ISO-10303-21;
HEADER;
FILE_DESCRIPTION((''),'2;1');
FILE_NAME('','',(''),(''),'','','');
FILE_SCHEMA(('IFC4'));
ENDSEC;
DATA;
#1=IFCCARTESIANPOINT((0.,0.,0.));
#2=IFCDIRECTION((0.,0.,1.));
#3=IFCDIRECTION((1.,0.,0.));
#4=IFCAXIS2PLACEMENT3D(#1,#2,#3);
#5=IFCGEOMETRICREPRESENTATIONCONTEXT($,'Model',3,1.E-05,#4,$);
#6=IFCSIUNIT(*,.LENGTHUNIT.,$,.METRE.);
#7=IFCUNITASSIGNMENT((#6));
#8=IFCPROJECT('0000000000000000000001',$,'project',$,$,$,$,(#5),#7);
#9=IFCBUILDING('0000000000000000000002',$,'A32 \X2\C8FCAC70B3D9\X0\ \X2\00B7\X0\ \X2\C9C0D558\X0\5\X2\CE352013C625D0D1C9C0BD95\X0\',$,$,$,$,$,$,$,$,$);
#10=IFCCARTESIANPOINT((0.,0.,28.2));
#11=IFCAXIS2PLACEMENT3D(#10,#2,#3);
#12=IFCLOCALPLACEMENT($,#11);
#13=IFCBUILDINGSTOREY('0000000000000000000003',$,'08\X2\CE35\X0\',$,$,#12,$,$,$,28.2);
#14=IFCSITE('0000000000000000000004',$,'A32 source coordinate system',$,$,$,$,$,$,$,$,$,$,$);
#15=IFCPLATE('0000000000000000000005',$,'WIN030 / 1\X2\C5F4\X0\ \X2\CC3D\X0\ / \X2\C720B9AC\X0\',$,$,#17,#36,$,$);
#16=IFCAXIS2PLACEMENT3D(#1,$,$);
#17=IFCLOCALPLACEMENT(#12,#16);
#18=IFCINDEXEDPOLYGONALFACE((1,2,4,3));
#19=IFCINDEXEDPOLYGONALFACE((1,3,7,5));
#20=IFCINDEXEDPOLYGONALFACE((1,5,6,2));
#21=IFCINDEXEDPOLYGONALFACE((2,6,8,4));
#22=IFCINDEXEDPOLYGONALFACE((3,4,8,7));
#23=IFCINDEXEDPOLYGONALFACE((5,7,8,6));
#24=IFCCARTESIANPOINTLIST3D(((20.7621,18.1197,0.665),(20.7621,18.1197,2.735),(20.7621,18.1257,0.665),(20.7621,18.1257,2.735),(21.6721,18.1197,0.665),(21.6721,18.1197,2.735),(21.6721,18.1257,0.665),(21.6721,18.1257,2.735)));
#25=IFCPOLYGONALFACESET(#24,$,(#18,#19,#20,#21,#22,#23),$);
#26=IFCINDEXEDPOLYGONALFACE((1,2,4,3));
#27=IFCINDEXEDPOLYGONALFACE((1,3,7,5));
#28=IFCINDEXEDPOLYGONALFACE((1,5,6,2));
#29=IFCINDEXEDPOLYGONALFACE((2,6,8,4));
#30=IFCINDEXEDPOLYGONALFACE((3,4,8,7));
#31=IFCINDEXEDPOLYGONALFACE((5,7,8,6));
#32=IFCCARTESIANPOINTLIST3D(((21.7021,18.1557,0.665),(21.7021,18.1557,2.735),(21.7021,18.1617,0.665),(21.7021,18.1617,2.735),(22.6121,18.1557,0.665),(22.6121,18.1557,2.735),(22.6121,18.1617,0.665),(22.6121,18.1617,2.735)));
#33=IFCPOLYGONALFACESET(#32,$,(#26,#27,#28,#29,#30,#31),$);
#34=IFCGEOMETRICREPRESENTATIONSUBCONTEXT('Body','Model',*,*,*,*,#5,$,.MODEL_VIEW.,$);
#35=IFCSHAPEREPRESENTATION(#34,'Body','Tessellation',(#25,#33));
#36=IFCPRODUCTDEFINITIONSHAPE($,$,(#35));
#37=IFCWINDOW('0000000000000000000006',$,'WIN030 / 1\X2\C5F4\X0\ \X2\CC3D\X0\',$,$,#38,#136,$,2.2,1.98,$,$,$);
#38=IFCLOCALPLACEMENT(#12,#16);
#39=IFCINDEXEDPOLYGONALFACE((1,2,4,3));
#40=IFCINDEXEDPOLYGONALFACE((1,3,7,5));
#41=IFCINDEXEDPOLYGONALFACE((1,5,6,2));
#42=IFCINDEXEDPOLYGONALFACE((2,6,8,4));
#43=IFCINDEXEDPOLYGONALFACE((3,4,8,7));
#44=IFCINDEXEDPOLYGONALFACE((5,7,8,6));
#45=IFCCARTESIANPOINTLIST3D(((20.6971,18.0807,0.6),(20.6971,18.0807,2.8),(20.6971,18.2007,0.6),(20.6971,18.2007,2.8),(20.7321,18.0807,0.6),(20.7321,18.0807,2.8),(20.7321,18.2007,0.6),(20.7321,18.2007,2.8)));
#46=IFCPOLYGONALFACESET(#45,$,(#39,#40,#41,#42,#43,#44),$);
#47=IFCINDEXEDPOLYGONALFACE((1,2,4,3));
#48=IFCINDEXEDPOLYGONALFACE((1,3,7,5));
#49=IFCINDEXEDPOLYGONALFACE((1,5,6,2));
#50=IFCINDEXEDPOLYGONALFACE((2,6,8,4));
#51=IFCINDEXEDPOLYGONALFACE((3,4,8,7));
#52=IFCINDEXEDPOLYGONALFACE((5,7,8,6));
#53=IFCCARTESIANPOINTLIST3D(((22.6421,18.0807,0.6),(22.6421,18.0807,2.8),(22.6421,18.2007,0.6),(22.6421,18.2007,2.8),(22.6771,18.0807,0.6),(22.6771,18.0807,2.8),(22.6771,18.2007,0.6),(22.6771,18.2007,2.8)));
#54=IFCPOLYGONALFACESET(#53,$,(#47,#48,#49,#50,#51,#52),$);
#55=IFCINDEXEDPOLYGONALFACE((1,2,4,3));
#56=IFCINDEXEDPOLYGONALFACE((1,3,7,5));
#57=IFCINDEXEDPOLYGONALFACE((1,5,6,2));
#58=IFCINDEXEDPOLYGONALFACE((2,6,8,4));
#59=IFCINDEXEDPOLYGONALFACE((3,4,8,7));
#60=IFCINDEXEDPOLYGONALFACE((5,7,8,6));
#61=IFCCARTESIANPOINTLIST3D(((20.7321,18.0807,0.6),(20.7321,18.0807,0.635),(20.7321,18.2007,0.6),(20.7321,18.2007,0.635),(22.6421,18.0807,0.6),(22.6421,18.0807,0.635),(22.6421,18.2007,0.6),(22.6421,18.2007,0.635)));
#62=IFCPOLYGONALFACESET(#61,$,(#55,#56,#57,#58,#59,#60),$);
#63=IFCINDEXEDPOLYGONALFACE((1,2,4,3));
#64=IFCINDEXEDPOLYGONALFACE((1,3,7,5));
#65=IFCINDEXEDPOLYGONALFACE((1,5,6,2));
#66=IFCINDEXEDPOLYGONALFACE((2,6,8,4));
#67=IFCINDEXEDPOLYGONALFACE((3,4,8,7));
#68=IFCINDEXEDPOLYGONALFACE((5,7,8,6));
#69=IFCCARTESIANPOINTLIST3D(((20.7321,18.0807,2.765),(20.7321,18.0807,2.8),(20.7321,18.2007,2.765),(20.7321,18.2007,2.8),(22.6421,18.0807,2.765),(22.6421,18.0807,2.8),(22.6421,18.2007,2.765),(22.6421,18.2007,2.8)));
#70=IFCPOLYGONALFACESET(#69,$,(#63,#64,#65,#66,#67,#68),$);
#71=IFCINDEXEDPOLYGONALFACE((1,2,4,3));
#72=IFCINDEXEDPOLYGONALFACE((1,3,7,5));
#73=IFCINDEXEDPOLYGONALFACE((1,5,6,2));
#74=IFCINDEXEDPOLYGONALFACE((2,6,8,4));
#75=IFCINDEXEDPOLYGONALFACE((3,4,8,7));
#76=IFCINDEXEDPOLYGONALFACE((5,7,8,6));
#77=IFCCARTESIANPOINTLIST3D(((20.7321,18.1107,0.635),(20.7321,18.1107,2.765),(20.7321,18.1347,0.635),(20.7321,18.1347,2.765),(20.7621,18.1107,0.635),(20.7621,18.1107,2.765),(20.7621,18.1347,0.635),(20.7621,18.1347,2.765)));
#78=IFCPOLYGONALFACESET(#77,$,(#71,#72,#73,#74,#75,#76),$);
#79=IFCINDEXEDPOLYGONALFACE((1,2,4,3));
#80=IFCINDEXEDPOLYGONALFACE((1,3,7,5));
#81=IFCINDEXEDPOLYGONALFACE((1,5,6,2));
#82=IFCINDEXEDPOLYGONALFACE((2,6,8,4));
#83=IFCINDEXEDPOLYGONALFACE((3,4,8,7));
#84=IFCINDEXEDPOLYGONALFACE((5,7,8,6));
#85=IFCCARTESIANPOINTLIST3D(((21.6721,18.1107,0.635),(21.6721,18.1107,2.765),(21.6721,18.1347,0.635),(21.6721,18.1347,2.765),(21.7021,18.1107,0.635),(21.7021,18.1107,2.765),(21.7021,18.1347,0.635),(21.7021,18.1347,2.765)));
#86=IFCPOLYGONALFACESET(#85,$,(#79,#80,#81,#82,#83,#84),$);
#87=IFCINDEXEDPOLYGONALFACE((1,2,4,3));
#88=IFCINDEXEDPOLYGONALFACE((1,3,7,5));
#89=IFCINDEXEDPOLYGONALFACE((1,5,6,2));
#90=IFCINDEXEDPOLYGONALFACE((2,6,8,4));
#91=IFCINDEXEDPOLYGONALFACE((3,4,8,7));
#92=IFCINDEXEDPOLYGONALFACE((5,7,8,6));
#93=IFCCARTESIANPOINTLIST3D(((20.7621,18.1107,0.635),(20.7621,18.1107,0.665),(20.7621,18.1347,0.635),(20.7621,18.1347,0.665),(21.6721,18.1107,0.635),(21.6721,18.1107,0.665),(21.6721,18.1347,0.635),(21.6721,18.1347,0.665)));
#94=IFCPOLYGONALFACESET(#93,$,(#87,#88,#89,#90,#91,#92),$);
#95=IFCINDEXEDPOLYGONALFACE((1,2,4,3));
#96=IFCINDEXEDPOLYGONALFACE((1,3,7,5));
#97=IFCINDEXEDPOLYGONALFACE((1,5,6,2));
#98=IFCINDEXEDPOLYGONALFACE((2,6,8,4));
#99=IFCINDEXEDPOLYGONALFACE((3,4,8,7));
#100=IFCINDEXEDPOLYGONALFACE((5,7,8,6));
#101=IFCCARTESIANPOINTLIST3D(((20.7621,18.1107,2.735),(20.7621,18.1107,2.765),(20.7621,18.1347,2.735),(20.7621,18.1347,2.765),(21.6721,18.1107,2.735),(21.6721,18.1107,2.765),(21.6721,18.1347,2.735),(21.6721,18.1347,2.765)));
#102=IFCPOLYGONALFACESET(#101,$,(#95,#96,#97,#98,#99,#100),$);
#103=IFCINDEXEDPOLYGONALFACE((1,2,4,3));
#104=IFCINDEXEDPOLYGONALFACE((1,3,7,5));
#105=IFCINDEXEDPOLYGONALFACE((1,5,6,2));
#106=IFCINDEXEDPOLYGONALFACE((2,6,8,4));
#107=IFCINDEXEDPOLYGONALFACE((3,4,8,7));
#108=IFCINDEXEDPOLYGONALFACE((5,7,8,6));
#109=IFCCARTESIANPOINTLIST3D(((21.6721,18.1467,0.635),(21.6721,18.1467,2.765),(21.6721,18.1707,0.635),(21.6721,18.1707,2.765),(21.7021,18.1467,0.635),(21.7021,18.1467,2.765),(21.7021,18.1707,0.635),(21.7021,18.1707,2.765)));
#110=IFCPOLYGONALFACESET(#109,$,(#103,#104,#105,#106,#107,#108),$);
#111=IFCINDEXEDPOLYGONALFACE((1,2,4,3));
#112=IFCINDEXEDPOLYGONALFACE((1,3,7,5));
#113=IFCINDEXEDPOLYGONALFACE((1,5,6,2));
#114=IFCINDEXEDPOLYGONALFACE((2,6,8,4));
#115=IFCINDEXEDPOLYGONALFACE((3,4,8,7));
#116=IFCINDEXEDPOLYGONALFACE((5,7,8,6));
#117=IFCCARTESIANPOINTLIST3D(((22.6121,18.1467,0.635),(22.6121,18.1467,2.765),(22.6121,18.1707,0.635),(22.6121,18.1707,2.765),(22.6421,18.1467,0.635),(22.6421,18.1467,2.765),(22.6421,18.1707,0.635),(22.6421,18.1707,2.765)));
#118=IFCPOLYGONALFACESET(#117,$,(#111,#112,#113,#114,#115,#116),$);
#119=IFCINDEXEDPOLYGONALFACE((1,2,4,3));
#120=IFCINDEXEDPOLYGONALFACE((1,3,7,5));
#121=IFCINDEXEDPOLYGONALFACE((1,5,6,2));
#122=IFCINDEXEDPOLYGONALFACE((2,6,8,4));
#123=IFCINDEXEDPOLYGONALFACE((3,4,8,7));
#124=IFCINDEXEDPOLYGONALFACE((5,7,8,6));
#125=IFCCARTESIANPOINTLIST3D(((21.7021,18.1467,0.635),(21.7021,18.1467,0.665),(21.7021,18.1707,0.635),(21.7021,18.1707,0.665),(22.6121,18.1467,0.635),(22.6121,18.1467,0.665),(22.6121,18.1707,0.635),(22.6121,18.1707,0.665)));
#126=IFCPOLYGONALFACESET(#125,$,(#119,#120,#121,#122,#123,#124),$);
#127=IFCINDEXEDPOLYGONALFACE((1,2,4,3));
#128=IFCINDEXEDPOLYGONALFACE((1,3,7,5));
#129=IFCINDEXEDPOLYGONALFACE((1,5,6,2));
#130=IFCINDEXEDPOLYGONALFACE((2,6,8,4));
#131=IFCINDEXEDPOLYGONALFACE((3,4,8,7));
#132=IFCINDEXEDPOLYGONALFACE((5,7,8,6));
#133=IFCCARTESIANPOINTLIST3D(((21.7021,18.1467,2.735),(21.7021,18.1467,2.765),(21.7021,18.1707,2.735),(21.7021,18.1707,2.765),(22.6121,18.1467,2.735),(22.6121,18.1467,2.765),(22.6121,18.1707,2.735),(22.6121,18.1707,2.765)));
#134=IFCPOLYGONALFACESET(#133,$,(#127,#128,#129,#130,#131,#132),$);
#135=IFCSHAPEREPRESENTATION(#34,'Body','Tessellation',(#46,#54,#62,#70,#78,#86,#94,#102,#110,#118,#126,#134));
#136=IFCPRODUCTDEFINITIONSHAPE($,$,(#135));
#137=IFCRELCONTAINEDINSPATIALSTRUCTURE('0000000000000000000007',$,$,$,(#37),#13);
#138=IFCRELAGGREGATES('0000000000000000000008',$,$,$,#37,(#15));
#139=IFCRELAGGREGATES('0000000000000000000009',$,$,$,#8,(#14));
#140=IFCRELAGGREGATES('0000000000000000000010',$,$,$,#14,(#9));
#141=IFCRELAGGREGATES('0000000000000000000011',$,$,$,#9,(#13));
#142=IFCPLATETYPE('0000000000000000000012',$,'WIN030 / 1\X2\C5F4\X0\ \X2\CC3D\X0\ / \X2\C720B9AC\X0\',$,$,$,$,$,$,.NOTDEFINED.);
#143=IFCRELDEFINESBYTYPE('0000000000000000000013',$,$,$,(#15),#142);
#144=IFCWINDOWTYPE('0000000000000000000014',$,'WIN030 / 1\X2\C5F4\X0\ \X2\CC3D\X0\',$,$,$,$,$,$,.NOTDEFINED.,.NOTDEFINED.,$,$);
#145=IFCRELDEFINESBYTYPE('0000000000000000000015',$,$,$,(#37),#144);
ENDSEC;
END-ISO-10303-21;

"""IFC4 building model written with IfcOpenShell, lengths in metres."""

from ifc_helpers import new_model, si_unit, frame, origin, origin_with_axes, place, context, subcontext, project, spatial, polyline, outline, extrude, source, transform, mapped, type_object, type_shapes, element, aggregate, save


model = new_model("IFC4")

# Units and contexts
model_context = context("Model", 3, precision=1e-05, world=origin_with_axes())
body_context = subcontext(model_context, "Body", "Model", "MODEL_VIEW")
ifc_project = project(units=[si_unit("LENGTHUNIT", "METRE")], contexts=[model_context])

# Plate
storey_placement = place(None, frame((0.0, 0.0, 28.2), z_axis=(0.0, 0.0, 1.0), x_axis=(1.0, 0.0, 0.0)))
plate_type_1 = type_object("IfcPlateType", Name="WIN030 / 1열 창 / 유리", PredefinedType="NOTDEFINED")
shared_shape_1 = source(origin(), body_context, "Body", "SweptSolid", [
    extrude(outline(polyline([(20.7621, 18.1197), (20.7621, 18.1257), (21.6721, 18.1257), (21.6721, 18.1197), (20.7621, 18.1197)])), frame((0.0, 0.0, 0.665)), (0.0, 0.0, 1.0), 2.07),
    extrude(outline(polyline([(21.7021, 18.1557), (21.7021, 18.1617), (22.6121, 18.1617), (22.6121, 18.1557), (21.7021, 18.1557)])), frame((0.0, 0.0, 0.665)), (0.0, 0.0, 1.0), 2.07),
])
type_shapes(plate_type_1, [shared_shape_1])
window_1_placement = place(storey_placement, origin_with_axes())
plate_1_placement = place(window_1_placement, origin_with_axes())
plate_1 = element("IfcPlate", 1, at=plate_1_placement, type_object=plate_type_1, Name="WIN030 / 1열 창 / 유리", context=body_context, shape_type="MappedRepresentation", body=[
    mapped(shared_shape_1, transform((0.0, 0.0, 0.0), scale=1.0)),
])

# Site, building, storey
site = spatial("IfcSite", under=ifc_project, Name="A32 source coordinate system")
building = spatial("IfcBuilding", under=site, Name="A32 주거동 · 지하5층–옥탑지붕")
storey = spatial("IfcBuildingStorey", under=building, at=storey_placement, Name="08층", Elevation=28.2)

# Window
window_type_1 = type_object("IfcWindowType", Name="WIN030 / 1열 창", PartitioningType="NOTDEFINED", PredefinedType="NOTDEFINED")
shared_shape_2 = source(origin(), body_context, "Body", "SweptSolid", [
    extrude(outline(polyline([(20.6971, 18.0807), (20.6971, 18.2007), (20.7321, 18.2007), (20.7321, 18.0807), (20.6971, 18.0807)])), frame((0.0, 0.0, 0.6)), (0.0, 0.0, 1.0), 2.2),
    extrude(outline(polyline([(22.6421, 18.0807), (22.6421, 18.2007), (22.6771, 18.2007), (22.6771, 18.0807), (22.6421, 18.0807)])), frame((0.0, 0.0, 0.6)), (0.0, 0.0, 1.0), 2.2),
    extrude(outline(polyline([(20.7321, 18.0807), (20.7321, 18.2007), (22.6421, 18.2007), (22.6421, 18.0807), (20.7321, 18.0807)])), frame((0.0, 0.0, 0.6)), (0.0, 0.0, 1.0), 0.035),
    extrude(outline(polyline([(20.7321, 18.0807), (20.7321, 18.2007), (22.6421, 18.2007), (22.6421, 18.0807), (20.7321, 18.0807)])), frame((0.0, 0.0, 2.765)), (0.0, 0.0, 1.0), 0.035),
    extrude(outline(polyline([(20.7321, 18.1107), (20.7321, 18.1347), (20.7621, 18.1347), (20.7621, 18.1107), (20.7321, 18.1107)])), frame((0.0, 0.0, 0.635)), (0.0, 0.0, 1.0), 2.13),
    extrude(outline(polyline([(21.6721, 18.1107), (21.6721, 18.1347), (21.7021, 18.1347), (21.7021, 18.1107), (21.6721, 18.1107)])), frame((0.0, 0.0, 0.635)), (0.0, 0.0, 1.0), 2.13),
    extrude(outline(polyline([(20.7621, 18.1107), (20.7621, 18.1347), (21.6721, 18.1347), (21.6721, 18.1107), (20.7621, 18.1107)])), frame((0.0, 0.0, 0.635)), (0.0, 0.0, 1.0), 0.03),
    extrude(outline(polyline([(20.7621, 18.1107), (20.7621, 18.1347), (21.6721, 18.1347), (21.6721, 18.1107), (20.7621, 18.1107)])), frame((0.0, 0.0, 2.735)), (0.0, 0.0, 1.0), 0.03),
    extrude(outline(polyline([(21.6721, 18.1467), (21.6721, 18.1707), (21.7021, 18.1707), (21.7021, 18.1467), (21.6721, 18.1467)])), frame((0.0, 0.0, 0.635)), (0.0, 0.0, 1.0), 2.13),
    extrude(outline(polyline([(22.6121, 18.1467), (22.6121, 18.1707), (22.6421, 18.1707), (22.6421, 18.1467), (22.6121, 18.1467)])), frame((0.0, 0.0, 0.635)), (0.0, 0.0, 1.0), 2.13),
    extrude(outline(polyline([(21.7021, 18.1467), (21.7021, 18.1707), (22.6121, 18.1707), (22.6121, 18.1467), (21.7021, 18.1467)])), frame((0.0, 0.0, 0.635)), (0.0, 0.0, 1.0), 0.03),
    extrude(outline(polyline([(21.7021, 18.1467), (21.7021, 18.1707), (22.6121, 18.1707), (22.6121, 18.1467), (21.7021, 18.1467)])), frame((0.0, 0.0, 2.735)), (0.0, 0.0, 1.0), 0.03),
])
type_shapes(window_type_1, [shared_shape_2])
window_1 = element("IfcWindow", 2, at=window_1_placement, inside=storey, type_object=window_type_1, Name="WIN030 / 1열 창", OverallHeight=2.2, OverallWidth=1.98, context=body_context, shape_type="MappedRepresentation", body=[
    mapped(shared_shape_2, transform((0.0, 0.0, 0.0), scale=1.0)),
])
aggregate(window_1, [plate_1])

save(model, "model.ifc")
